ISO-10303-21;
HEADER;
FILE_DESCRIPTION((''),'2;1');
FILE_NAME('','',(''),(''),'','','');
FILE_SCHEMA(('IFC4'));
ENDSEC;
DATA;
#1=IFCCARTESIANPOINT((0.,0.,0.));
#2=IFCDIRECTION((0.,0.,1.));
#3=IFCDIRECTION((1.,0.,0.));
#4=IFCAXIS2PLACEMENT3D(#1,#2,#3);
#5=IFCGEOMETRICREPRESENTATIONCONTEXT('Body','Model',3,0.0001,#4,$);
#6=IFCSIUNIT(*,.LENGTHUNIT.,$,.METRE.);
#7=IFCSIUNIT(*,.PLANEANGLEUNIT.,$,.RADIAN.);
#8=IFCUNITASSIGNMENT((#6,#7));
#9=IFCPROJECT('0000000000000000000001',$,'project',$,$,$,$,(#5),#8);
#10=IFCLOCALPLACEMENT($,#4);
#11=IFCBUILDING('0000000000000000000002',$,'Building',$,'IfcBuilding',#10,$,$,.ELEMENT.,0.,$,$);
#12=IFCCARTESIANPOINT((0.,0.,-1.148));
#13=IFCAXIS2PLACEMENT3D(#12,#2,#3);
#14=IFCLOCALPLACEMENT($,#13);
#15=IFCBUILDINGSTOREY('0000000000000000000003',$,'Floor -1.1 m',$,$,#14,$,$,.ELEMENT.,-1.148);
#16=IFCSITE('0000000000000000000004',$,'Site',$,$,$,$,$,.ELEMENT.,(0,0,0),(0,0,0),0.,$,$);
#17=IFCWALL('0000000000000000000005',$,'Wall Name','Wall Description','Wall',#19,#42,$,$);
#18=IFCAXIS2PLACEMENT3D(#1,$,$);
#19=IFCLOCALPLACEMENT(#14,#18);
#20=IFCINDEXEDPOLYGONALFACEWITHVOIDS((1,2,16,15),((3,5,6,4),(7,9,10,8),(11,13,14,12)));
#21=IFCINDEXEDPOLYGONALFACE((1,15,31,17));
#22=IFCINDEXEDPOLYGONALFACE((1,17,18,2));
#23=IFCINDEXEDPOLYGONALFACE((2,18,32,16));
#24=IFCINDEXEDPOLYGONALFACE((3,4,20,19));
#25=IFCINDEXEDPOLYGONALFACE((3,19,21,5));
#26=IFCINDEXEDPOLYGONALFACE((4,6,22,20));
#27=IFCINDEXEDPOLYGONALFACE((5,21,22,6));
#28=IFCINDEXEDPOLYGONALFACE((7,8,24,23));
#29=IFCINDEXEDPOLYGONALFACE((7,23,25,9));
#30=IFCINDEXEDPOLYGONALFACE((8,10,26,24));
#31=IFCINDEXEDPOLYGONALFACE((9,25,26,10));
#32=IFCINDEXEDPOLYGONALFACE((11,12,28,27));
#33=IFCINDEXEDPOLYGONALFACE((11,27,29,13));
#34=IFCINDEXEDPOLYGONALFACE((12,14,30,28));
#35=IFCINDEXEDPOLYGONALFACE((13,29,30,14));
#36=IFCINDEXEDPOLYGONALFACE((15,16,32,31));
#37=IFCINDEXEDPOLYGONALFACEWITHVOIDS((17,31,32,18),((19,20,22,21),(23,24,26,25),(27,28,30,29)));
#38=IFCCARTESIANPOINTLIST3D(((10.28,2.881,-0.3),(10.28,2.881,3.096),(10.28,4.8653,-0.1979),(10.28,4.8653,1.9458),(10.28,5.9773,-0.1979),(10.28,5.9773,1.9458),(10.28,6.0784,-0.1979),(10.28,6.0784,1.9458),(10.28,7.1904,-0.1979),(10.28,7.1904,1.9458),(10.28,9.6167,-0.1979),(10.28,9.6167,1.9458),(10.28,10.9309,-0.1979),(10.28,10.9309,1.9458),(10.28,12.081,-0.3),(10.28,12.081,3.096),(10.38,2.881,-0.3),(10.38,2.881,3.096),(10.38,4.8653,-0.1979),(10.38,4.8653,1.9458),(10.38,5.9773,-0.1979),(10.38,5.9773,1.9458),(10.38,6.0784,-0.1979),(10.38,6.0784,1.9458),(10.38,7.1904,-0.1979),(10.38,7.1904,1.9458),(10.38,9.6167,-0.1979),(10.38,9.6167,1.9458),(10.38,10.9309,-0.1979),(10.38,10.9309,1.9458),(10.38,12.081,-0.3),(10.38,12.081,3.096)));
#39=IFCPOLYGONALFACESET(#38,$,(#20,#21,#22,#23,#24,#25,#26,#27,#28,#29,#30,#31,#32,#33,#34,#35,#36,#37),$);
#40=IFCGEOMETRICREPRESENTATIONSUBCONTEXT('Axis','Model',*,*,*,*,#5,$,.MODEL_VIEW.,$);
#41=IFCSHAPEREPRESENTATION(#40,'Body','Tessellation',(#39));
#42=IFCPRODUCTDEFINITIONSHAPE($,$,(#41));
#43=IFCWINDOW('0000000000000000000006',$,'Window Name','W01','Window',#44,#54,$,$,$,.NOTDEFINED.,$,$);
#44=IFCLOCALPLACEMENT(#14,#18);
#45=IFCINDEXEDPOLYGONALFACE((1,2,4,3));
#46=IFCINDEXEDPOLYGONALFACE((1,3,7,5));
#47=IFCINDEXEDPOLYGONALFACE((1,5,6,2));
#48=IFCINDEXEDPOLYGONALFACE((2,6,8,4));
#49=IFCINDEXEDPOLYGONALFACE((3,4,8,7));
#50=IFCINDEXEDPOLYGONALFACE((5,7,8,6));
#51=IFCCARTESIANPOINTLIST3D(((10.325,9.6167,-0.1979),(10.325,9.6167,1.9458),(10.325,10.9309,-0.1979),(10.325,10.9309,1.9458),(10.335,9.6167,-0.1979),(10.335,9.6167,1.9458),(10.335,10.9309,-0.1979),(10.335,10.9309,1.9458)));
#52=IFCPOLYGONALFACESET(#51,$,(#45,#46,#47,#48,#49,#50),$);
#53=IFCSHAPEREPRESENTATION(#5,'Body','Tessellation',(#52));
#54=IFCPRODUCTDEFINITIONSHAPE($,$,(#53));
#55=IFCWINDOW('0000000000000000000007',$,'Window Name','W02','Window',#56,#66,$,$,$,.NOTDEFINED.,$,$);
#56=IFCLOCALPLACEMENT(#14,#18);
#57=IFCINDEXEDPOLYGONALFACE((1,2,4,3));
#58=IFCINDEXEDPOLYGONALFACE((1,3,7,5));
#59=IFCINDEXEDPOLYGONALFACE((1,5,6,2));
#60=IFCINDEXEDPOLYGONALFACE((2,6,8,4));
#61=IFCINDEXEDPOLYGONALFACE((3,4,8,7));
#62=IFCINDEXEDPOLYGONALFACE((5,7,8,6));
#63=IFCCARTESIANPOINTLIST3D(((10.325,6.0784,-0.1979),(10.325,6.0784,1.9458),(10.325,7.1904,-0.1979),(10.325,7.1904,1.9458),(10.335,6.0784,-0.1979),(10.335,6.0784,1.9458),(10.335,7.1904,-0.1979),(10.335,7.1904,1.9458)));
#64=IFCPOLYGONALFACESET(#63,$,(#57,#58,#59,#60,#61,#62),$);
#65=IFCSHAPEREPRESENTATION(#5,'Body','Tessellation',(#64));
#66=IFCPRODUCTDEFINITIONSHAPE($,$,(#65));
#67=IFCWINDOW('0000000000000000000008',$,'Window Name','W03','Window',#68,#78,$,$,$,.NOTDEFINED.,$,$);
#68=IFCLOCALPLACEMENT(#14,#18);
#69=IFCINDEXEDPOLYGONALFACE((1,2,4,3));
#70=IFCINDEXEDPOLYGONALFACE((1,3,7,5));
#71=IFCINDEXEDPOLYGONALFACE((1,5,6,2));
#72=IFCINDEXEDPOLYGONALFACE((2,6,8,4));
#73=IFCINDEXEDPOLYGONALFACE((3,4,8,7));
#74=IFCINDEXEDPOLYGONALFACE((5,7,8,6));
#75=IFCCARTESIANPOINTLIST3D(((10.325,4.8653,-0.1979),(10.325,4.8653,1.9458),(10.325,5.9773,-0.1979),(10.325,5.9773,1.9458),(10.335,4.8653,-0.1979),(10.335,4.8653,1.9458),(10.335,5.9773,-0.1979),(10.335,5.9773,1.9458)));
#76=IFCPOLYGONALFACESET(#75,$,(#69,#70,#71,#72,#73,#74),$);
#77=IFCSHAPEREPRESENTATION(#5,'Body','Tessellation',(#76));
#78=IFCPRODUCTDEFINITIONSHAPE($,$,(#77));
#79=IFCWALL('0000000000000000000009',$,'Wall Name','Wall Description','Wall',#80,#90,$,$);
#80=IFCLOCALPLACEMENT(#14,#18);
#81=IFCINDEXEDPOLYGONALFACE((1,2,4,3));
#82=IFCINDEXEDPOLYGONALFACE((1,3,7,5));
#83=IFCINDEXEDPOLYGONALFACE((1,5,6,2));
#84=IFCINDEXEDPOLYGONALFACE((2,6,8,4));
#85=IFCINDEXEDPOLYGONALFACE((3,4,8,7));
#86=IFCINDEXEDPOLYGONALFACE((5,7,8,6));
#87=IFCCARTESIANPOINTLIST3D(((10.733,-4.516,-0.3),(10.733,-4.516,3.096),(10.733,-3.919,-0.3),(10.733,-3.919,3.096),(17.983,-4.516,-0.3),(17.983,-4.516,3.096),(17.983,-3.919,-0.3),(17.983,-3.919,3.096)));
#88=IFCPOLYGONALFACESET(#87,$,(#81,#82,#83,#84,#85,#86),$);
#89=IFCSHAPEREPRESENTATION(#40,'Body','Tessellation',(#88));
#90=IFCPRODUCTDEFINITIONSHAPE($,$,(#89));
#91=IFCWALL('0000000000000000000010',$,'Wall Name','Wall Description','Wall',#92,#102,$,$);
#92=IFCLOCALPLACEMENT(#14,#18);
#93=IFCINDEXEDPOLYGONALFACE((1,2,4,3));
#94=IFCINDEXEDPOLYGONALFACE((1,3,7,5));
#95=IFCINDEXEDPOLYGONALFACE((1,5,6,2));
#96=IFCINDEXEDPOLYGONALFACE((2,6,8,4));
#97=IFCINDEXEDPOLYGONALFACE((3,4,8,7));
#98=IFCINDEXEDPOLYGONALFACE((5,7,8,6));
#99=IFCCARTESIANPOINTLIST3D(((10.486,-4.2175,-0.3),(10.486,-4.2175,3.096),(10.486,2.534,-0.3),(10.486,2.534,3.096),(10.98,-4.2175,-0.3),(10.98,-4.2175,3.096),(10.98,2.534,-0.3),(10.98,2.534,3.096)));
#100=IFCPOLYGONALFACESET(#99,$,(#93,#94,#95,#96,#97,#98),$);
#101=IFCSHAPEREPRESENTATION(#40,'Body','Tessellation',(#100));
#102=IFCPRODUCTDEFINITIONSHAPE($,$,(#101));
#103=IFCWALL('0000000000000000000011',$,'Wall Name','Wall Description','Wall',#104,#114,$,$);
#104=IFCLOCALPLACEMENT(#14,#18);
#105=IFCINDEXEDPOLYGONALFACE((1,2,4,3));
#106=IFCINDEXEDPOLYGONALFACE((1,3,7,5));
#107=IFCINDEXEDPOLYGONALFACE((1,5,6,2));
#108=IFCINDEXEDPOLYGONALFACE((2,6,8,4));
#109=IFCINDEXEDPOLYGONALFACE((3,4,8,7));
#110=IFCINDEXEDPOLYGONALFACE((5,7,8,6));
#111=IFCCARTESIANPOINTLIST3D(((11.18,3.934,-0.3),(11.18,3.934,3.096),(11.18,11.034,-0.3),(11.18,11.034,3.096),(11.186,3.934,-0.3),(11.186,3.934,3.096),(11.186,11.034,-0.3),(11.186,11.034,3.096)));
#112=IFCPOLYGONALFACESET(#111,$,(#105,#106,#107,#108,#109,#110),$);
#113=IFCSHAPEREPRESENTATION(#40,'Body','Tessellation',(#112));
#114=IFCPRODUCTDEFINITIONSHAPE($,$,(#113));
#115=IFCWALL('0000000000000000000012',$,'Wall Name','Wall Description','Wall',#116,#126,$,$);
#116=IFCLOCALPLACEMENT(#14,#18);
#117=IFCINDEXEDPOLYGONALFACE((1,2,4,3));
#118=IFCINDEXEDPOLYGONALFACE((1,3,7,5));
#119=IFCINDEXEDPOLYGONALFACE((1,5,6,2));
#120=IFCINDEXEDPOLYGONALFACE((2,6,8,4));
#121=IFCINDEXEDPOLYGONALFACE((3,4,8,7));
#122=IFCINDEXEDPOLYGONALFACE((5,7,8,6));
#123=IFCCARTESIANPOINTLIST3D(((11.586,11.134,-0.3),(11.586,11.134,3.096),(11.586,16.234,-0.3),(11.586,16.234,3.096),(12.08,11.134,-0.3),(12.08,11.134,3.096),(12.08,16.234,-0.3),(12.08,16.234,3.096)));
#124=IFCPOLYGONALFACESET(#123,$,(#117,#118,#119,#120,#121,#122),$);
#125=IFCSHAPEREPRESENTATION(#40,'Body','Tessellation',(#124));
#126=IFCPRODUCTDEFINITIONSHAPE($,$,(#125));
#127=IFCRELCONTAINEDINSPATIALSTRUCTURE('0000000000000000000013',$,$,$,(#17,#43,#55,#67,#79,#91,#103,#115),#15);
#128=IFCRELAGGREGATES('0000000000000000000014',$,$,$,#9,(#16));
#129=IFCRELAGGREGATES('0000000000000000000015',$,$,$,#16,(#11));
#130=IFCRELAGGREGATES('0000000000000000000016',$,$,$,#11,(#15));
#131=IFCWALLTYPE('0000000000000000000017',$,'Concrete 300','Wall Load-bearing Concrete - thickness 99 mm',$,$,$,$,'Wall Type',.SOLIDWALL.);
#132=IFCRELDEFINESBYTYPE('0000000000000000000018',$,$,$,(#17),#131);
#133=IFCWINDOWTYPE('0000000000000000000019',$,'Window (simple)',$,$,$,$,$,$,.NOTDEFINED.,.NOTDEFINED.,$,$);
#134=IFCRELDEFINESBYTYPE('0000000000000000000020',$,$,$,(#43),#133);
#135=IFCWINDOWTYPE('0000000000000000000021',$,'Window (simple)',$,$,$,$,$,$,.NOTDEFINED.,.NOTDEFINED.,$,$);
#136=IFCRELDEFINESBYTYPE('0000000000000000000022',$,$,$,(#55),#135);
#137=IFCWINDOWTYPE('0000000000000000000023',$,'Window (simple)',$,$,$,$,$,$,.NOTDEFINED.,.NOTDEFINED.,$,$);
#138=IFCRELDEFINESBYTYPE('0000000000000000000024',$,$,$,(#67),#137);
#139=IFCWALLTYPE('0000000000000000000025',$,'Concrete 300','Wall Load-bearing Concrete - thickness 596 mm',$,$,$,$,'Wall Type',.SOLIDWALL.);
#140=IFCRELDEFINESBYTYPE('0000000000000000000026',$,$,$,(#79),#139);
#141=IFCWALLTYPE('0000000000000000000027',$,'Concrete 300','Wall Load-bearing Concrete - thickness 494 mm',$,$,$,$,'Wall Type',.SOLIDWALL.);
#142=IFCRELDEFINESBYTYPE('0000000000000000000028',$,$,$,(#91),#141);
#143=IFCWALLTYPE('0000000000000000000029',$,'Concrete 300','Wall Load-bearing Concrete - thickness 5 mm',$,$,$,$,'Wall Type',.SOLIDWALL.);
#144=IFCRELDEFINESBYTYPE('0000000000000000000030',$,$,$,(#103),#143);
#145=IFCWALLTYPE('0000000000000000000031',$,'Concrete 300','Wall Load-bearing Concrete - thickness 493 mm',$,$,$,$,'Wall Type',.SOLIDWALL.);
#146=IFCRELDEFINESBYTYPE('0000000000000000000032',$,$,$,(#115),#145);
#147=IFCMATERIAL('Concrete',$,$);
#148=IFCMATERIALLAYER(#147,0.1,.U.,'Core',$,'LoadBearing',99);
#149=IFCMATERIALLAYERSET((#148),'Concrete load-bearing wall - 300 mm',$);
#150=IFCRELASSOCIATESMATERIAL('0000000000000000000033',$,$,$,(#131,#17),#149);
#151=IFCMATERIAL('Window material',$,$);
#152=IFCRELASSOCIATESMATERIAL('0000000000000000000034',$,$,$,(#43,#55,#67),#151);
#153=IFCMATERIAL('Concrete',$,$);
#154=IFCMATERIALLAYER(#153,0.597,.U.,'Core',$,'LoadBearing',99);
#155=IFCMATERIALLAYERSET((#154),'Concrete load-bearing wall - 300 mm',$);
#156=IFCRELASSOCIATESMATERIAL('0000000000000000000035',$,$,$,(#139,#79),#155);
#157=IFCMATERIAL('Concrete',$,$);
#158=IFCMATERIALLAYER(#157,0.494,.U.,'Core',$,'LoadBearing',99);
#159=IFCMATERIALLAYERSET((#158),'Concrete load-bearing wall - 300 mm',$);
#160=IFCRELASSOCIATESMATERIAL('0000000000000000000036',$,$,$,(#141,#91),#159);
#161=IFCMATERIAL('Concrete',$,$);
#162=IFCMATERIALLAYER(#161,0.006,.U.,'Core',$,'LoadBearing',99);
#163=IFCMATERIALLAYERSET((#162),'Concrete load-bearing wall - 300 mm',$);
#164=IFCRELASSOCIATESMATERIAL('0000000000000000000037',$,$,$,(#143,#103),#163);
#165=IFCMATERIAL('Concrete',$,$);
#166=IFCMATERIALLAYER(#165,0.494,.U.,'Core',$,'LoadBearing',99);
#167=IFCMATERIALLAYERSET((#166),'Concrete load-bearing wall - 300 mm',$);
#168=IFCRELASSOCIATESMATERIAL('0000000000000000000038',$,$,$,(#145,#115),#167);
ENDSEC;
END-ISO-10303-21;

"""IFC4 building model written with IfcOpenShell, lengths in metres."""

from ifc_helpers import new_model, si_unit, frame, frame_2d, origin_with_axes, place, context, subcontext, project, spatial, polyline, rectangle, outline, extrude, material, layer, layer_set, layer_usage, type_object, element, fill, save


model = new_model("IFC4")

# Units and contexts
model_context = context("Model", 3, precision=0.0001, world=origin_with_axes(), identifier="Body")
axis_context = subcontext(model_context, "Axis", "Model", "MODEL_VIEW")
ifc_project = project(units=[si_unit("LENGTHUNIT", "METRE"), si_unit("PLANEANGLEUNIT", "RADIAN")], contexts=[model_context])

# Site, building, storey
site = spatial("IfcSite", under=ifc_project, Name="Site", CompositionType="ELEMENT", RefLatitude=(0, 0, 0), RefLongitude=(0, 0, 0), RefElevation=0.0)
building_placement = place(None, origin_with_axes())
building = spatial("IfcBuilding", under=site, at=building_placement, Name="Building", ObjectType="IfcBuilding", CompositionType="ELEMENT", ElevationOfRefHeight=0.0)
storey_placement = place(None, frame((0.0, 0.0, -1.148), z_axis=(0.0, 0.0, 1.0), x_axis=(1.0, 0.0, 0.0)))
storey = spatial("IfcBuildingStorey", under=building, at=storey_placement, Name="Floor -1.1 m", CompositionType="ELEMENT", Elevation=-1.148)

# Wall, openings, windows
ifc_material_1 = material(Name="Concrete")
ifc_layer_1 = layer(ifc_material_1, 0.1, ventilated="UNKNOWN", Name="Core", Category="LoadBearing", Priority=99)
ifc_layer_set_1 = layer_set([ifc_layer_1], Name="Concrete load-bearing wall - 300 mm")
ifc_layer_usage_1 = layer_usage(ifc_layer_set_1, "AXIS2", "POSITIVE", -0.05)
wall_type_1 = type_object("IfcWallType", Name="Concrete 300", Description="Wall Load-bearing Concrete - thickness 99 mm", ElementType="Wall Type", PredefinedType="SOLIDWALL", material=ifc_layer_set_1)
wall_1_placement = place(None, frame((0.0, 0.0, -1.448)))
wall_1 = element("IfcWall", 1, at=wall_1_placement, inside=storey, type_object=wall_type_1, material=ifc_layer_usage_1, Name="Wall Name", Description="Wall Description", ObjectType="Wall", context=axis_context, shape_type="SweptSolid", body=[
    extrude(rectangle(XDim=9.2, YDim=0.1, at=frame_2d((10.33, 7.481), x_axis=(0.0, -1.0))), None, (0.0, 0.0, 1.0), 3.396),
])
placement_1 = place(wall_1_placement, frame((10.33, 12.081, 0.0), z_axis=(0.0, 0.0, 1.0), x_axis=(1.0, 0.0, 0.0)))
opening_1 = element("IfcOpeningElement", 2, at=placement_1, cuts=wall_1, PredefinedType="OPENING", context=model_context, shape_type="SweptSolid", body=[
    extrude(outline(polyline([(0.0, -0.05), (0.0, 0.05), (1.3142, 0.05), (1.3142, -0.05), (0.0, -0.05)])), frame((0.0, -1.1501, 0.1021), z_axis=(0.0, 0.0, 1.0), x_axis=(0.0, -1.0, 0.0)), (0.0, 0.0, 1.0), 2.1437),
])
placement_2 = place(wall_1_placement, frame((10.33, 12.081, 0.0), z_axis=(0.0, 0.0, 1.0), x_axis=(1.0, 0.0, 0.0)))
opening_2 = element("IfcOpeningElement", 3, at=placement_2, cuts=wall_1, PredefinedType="OPENING", context=model_context, shape_type="SweptSolid", body=[
    extrude(outline(polyline([(0.0, -0.05), (0.0, 0.05), (1.112, 0.05), (1.112, -0.05), (0.0, -0.05)])), frame((0.0, -4.8906, 0.1021), z_axis=(0.0, 0.0, 1.0), x_axis=(0.0, -1.0, 0.0)), (0.0, 0.0, 1.0), 2.1437),
])
placement_3 = place(wall_1_placement, frame((10.33, 12.081, 0.0), z_axis=(0.0, 0.0, 1.0), x_axis=(1.0, 0.0, 0.0)))
opening_3 = element("IfcOpeningElement", 4, at=placement_3, cuts=wall_1, PredefinedType="OPENING", context=model_context, shape_type="SweptSolid", body=[
    extrude(outline(polyline([(0.0, -0.05), (0.0, 0.05), (1.112, 0.05), (1.112, -0.05), (0.0, -0.05)])), frame((0.0, -6.1037, 0.1021), z_axis=(0.0, 0.0, 1.0), x_axis=(0.0, -1.0, 0.0)), (0.0, 0.0, 1.0), 2.1437),
])
ifc_material_2 = material(Name="Window material")
window_type_1 = type_object("IfcWindowType", Name="Window (simple)", PredefinedType="NOTDEFINED")
window_1 = element("IfcWindow", 5, at=placement_1, inside=storey, type_object=window_type_1, material=ifc_material_2, Name="Window Name", Description="W01", ObjectType="Window", PredefinedType="NOTDEFINED", context=model_context, shape_type="SweptSolid", body=[
    extrude(outline(polyline([(0.0, -0.005), (0.0, 0.005), (1.3142, 0.005), (1.3142, -0.005), (0.0, -0.005)])), frame((0.0, -1.1501, 0.1021), z_axis=(0.0, 0.0, 1.0), x_axis=(0.0, -1.0, 0.0)), (0.0, 0.0, 1.0), 2.1437),
])
fill(opening_1, window_1)
window_type_2 = type_object("IfcWindowType", Name="Window (simple)", PredefinedType="NOTDEFINED")
window_2 = element("IfcWindow", 6, at=placement_2, inside=storey, type_object=window_type_2, material=ifc_material_2, Name="Window Name", Description="W02", ObjectType="Window", PredefinedType="NOTDEFINED", context=model_context, shape_type="SweptSolid", body=[
    extrude(outline(polyline([(0.0, -0.005), (0.0, 0.005), (1.112, 0.005), (1.112, -0.005), (0.0, -0.005)])), frame((0.0, -4.8906, 0.1021), z_axis=(0.0, 0.0, 1.0), x_axis=(0.0, -1.0, 0.0)), (0.0, 0.0, 1.0), 2.1437),
])
fill(opening_2, window_2)
window_type_3 = type_object("IfcWindowType", Name="Window (simple)", PredefinedType="NOTDEFINED")
window_3 = element("IfcWindow", 7, at=placement_3, inside=storey, type_object=window_type_3, material=ifc_material_2, Name="Window Name", Description="W03", ObjectType="Window", PredefinedType="NOTDEFINED", context=model_context, shape_type="SweptSolid", body=[
    extrude(outline(polyline([(0.0, -0.005), (0.0, 0.005), (1.112, 0.005), (1.112, -0.005), (0.0, -0.005)])), frame((0.0, -6.1037, 0.1021), z_axis=(0.0, 0.0, 1.0), x_axis=(0.0, -1.0, 0.0)), (0.0, 0.0, 1.0), 2.1437),
])
fill(opening_3, window_3)

# Walls
ifc_material_3 = material(Name="Concrete")
ifc_layer_2 = layer(ifc_material_3, 0.597, ventilated="UNKNOWN", Name="Core", Category="LoadBearing", Priority=99)
ifc_layer_set_2 = layer_set([ifc_layer_2], Name="Concrete load-bearing wall - 300 mm")
ifc_layer_usage_2 = layer_usage(ifc_layer_set_2, "AXIS2", "POSITIVE", -0.2985)
wall_type_2 = type_object("IfcWallType", Name="Concrete 300", Description="Wall Load-bearing Concrete - thickness 596 mm", ElementType="Wall Type", PredefinedType="SOLIDWALL", material=ifc_layer_set_2)
wall_2_placement = place(None, frame((0.0, 0.0, -1.448)))
element("IfcWall", 8, at=wall_2_placement, inside=storey, type_object=wall_type_2, material=ifc_layer_usage_2, Name="Wall Name", Description="Wall Description", ObjectType="Wall", context=axis_context, shape_type="SweptSolid", body=[
    extrude(rectangle(XDim=7.25, YDim=0.597, at=frame_2d((14.358, -4.2175), x_axis=(-1.0, 0.0))), None, (0.0, 0.0, 1.0), 3.396),
])
ifc_material_4 = material(Name="Concrete")
ifc_layer_3 = layer(ifc_material_4, 0.494, ventilated="UNKNOWN", Name="Core", Category="LoadBearing", Priority=99)
ifc_layer_set_3 = layer_set([ifc_layer_3], Name="Concrete load-bearing wall - 300 mm")
ifc_layer_usage_3 = layer_usage(ifc_layer_set_3, "AXIS2", "POSITIVE", -0.247)
wall_type_3 = type_object("IfcWallType", Name="Concrete 300", Description="Wall Load-bearing Concrete - thickness 494 mm", ElementType="Wall Type", PredefinedType="SOLIDWALL", material=ifc_layer_set_3)
wall_3_placement = place(None, frame((0.0, 0.0, -1.448)))
element("IfcWall", 9, at=wall_3_placement, inside=storey, type_object=wall_type_3, material=ifc_layer_usage_3, Name="Wall Name", Description="Wall Description", ObjectType="Wall", context=axis_context, shape_type="SweptSolid", body=[
    extrude(rectangle(XDim=6.7515, YDim=0.494, at=frame_2d((10.733, -0.8418), x_axis=(0.0, 1.0))), None, (0.0, 0.0, 1.0), 3.396),
])
ifc_material_5 = material(Name="Concrete")
ifc_layer_4 = layer(ifc_material_5, 0.006, ventilated="UNKNOWN", Name="Core", Category="LoadBearing", Priority=99)
ifc_layer_set_4 = layer_set([ifc_layer_4], Name="Concrete load-bearing wall - 300 mm")
ifc_layer_usage_4 = layer_usage(ifc_layer_set_4, "AXIS2", "POSITIVE", -0.003)
wall_type_4 = type_object("IfcWallType", Name="Concrete 300", Description="Wall Load-bearing Concrete - thickness 5 mm", ElementType="Wall Type", PredefinedType="SOLIDWALL", material=ifc_layer_set_4)
wall_4_placement = place(None, frame((0.0, 0.0, -1.448)))
element("IfcWall", 10, at=wall_4_placement, inside=storey, type_object=wall_type_4, material=ifc_layer_usage_4, Name="Wall Name", Description="Wall Description", ObjectType="Wall", context=axis_context, shape_type="SweptSolid", body=[
    extrude(rectangle(XDim=7.1, YDim=0.006, at=frame_2d((11.183, 7.484), x_axis=(0.0, 1.0))), None, (0.0, 0.0, 1.0), 3.396),
])
ifc_material_6 = material(Name="Concrete")
ifc_layer_5 = layer(ifc_material_6, 0.494, ventilated="UNKNOWN", Name="Core", Category="LoadBearing", Priority=99)
ifc_layer_set_5 = layer_set([ifc_layer_5], Name="Concrete load-bearing wall - 300 mm")
ifc_layer_usage_5 = layer_usage(ifc_layer_set_5, "AXIS2", "POSITIVE", -0.247)
wall_type_5 = type_object("IfcWallType", Name="Concrete 300", Description="Wall Load-bearing Concrete - thickness 493 mm", ElementType="Wall Type", PredefinedType="SOLIDWALL", material=ifc_layer_set_5)
wall_5_placement = place(None, frame((0.0, 0.0, -1.448)))
element("IfcWall", 11, at=wall_5_placement, inside=storey, type_object=wall_type_5, material=ifc_layer_usage_5, Name="Wall Name", Description="Wall Description", ObjectType="Wall", context=axis_context, shape_type="SweptSolid", body=[
    extrude(rectangle(XDim=5.1, YDim=0.494, at=frame_2d((11.833, 13.684), x_axis=(0.0, 1.0))), None, (0.0, 0.0, 1.0), 3.396),
])

save(model, "model.ifc")
